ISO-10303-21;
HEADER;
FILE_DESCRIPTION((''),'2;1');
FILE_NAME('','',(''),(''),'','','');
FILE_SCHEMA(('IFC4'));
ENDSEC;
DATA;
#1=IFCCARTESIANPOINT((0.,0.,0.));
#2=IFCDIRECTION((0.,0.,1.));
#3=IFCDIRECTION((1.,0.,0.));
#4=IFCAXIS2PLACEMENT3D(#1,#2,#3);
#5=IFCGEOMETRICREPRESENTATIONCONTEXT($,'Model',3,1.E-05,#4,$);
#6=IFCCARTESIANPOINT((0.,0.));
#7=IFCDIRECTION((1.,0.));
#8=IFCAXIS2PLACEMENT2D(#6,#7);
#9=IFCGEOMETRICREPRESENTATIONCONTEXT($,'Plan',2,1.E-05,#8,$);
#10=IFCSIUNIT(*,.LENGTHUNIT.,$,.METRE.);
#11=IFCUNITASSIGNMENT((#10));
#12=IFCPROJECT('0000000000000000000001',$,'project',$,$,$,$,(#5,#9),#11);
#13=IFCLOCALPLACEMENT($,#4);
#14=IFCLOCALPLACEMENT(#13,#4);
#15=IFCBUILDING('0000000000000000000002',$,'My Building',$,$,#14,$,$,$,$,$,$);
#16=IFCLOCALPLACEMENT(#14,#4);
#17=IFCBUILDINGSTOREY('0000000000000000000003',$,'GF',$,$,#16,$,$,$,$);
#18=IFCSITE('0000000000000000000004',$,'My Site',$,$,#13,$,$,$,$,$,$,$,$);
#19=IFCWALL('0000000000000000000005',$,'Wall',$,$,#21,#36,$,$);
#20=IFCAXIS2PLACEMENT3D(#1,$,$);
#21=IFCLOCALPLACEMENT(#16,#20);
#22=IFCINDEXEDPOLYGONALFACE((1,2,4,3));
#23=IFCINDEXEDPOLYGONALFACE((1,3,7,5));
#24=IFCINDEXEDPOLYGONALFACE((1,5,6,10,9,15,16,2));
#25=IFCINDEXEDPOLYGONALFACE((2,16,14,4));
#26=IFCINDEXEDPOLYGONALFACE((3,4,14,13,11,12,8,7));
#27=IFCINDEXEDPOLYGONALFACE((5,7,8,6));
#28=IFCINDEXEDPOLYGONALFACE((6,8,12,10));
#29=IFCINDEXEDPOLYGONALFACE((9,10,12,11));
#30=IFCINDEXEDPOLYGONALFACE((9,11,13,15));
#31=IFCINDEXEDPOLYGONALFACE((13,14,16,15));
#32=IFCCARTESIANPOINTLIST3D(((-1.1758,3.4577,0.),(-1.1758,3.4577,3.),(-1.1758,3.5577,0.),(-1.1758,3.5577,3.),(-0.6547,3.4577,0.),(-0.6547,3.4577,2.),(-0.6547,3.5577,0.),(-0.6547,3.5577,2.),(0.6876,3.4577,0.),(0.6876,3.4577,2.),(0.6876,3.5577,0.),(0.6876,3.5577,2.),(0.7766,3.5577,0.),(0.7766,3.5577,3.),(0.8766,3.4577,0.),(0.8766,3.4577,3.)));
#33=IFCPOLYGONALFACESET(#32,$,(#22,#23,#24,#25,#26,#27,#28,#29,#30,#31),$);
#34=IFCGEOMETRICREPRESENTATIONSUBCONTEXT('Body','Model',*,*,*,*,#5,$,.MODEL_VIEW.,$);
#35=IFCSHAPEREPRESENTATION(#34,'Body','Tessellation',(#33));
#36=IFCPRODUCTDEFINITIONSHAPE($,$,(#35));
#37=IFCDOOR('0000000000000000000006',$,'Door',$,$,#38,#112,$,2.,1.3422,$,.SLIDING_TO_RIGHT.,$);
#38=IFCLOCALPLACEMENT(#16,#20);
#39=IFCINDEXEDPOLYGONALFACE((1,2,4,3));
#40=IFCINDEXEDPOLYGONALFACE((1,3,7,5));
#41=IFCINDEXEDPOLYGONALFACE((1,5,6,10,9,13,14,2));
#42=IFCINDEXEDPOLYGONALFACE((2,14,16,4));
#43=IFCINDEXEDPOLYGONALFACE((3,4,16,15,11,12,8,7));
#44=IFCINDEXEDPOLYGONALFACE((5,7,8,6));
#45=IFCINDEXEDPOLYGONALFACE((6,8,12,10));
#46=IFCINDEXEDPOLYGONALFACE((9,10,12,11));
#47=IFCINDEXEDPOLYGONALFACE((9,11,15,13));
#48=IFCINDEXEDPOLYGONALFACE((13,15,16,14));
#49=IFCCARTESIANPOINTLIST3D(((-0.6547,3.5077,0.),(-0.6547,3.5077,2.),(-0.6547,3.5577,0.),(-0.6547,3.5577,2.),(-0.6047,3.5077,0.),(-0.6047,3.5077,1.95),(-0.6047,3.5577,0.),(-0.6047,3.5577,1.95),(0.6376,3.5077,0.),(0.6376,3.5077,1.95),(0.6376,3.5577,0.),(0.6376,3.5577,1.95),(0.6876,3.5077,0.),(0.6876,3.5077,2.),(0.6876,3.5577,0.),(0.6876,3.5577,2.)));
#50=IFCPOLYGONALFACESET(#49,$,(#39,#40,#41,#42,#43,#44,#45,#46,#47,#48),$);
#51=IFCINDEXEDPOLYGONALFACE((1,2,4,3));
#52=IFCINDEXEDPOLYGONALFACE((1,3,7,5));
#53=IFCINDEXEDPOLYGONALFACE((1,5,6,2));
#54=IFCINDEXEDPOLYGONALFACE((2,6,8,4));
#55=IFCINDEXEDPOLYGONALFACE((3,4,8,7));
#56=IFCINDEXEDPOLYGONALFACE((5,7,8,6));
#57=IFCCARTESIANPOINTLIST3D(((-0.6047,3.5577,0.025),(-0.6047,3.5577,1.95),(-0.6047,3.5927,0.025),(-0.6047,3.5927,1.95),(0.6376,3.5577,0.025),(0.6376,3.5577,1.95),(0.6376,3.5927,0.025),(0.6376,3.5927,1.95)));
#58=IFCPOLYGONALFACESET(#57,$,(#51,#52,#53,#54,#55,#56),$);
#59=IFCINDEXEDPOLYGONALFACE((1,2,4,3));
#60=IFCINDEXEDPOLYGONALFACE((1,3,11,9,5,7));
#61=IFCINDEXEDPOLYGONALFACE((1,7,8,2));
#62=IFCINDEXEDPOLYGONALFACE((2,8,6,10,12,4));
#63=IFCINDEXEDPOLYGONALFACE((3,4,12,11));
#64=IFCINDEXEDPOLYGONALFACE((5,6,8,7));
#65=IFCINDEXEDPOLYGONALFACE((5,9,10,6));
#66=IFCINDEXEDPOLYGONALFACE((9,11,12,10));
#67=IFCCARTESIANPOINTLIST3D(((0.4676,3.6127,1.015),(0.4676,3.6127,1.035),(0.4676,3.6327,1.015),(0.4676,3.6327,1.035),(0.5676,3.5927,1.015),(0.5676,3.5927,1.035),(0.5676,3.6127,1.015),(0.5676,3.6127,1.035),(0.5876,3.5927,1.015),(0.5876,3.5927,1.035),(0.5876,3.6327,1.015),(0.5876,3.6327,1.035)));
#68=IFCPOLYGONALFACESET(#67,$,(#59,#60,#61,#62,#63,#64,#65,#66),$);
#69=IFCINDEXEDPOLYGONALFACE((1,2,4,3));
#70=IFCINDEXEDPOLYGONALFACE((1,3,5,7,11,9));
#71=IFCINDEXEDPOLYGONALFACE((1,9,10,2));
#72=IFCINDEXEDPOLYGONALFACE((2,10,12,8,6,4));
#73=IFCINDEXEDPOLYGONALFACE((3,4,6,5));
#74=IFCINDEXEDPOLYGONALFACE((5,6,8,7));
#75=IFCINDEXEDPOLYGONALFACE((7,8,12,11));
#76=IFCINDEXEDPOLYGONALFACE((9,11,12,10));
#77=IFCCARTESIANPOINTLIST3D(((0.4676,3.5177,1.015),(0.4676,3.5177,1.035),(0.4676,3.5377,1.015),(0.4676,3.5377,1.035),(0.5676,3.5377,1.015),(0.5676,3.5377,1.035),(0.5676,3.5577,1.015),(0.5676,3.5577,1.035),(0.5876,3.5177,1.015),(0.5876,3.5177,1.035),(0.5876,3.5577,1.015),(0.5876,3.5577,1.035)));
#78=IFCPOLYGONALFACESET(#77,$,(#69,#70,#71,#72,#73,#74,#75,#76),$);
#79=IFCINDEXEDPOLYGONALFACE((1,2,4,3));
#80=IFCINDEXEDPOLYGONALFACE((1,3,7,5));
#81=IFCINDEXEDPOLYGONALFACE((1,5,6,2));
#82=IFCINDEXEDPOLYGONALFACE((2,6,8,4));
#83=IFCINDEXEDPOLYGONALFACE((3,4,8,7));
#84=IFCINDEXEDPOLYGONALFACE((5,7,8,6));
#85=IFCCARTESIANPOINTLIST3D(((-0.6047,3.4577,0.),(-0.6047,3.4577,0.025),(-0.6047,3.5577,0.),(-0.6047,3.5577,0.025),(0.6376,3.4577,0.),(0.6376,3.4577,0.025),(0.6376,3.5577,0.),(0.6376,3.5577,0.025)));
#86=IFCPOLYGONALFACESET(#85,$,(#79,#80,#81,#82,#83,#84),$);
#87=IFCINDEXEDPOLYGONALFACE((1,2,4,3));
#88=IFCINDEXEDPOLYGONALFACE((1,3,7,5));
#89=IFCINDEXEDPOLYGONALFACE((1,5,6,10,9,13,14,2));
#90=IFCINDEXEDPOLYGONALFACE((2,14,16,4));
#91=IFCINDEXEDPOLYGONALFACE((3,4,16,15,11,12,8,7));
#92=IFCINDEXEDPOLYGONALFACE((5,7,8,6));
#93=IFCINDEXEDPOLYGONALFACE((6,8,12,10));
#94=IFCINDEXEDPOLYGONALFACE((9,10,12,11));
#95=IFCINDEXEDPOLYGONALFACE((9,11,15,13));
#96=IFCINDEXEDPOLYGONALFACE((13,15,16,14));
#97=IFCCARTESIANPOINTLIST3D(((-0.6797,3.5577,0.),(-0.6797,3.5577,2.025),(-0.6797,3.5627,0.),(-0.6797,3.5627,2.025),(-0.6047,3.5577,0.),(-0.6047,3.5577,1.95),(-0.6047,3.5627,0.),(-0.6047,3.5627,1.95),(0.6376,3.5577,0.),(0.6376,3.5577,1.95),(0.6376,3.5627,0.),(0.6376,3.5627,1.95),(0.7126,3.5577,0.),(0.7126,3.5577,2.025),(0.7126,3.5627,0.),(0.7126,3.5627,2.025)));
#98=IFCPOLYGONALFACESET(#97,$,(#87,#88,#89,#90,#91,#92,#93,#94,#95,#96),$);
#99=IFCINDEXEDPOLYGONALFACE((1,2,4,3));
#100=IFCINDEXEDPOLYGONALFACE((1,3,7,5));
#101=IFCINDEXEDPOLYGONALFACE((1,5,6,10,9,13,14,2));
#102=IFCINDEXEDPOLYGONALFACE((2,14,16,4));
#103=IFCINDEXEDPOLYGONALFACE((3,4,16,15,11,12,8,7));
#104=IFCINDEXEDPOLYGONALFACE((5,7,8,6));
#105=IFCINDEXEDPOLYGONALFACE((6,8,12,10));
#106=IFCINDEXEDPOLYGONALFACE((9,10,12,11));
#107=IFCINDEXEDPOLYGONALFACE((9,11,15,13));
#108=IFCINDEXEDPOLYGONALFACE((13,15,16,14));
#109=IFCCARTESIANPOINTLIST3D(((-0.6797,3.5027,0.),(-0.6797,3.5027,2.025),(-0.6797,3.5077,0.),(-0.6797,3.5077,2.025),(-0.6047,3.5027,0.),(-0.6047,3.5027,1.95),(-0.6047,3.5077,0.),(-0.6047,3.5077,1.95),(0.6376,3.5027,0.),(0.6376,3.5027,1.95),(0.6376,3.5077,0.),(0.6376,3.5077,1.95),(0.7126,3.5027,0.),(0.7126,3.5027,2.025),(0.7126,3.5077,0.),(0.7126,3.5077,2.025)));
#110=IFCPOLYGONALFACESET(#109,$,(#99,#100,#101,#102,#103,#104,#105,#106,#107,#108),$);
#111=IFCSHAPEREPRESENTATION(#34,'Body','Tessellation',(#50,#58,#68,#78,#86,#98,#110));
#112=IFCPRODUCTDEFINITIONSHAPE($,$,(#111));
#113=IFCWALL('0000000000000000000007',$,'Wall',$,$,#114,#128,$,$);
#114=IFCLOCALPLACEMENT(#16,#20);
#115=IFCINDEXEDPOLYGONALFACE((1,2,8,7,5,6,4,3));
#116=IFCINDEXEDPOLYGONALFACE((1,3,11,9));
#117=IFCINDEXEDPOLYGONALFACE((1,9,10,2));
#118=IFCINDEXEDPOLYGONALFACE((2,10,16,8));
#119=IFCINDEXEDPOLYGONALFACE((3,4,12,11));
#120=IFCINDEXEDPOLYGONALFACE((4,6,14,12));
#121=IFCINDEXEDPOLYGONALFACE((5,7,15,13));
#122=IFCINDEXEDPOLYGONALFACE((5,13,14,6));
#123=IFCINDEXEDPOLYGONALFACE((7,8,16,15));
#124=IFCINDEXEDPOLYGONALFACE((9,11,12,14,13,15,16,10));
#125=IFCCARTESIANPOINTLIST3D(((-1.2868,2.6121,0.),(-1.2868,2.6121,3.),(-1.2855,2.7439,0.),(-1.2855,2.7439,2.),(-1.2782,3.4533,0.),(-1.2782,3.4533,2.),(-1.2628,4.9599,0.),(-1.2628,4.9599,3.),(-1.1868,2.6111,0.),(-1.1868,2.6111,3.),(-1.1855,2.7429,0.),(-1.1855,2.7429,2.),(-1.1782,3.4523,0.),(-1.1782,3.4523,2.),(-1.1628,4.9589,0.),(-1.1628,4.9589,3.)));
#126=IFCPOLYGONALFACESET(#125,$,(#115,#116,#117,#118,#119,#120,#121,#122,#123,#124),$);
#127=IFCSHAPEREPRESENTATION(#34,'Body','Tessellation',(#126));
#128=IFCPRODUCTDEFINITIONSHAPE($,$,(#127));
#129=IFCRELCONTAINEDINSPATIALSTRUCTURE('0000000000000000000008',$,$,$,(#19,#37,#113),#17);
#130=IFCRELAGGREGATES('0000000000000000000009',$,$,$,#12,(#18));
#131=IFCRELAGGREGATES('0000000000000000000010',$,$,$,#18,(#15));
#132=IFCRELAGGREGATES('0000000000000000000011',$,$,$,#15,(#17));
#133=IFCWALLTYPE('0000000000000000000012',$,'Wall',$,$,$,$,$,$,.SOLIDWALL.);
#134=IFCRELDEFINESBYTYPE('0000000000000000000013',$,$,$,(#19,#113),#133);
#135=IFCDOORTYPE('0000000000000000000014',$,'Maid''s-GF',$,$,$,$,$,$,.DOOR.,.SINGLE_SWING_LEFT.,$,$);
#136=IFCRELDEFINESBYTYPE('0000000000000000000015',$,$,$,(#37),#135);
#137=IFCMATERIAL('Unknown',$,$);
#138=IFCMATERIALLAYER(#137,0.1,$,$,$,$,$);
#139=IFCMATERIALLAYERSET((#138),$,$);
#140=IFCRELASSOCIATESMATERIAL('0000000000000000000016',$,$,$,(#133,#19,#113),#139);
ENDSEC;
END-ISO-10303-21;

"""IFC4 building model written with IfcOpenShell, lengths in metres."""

from ifc_helpers import new_model, entity, si_unit, frame, origin_with_axes, origin_2d_with_axis, place, context, subcontext, project, spatial, line, indexed_curve, outline, extrude, shape, source, transform, mapped, material, layer, layer_set, layer_usage, type_object, type_shapes, element, fill, save


model = new_model("IFC4")

# Units and contexts
model_context = context("Model", 3, precision=1e-05, world=origin_with_axes())
plan_context = context("Plan", 2, precision=1e-05, world=origin_2d_with_axis())
body_context_1 = subcontext(model_context, "Body", "Model", "MODEL_VIEW")
body_context_2 = subcontext(plan_context, "Body", "Plan", "PLAN_VIEW")
ifc_project = project(units=[si_unit("LENGTHUNIT", "METRE")], contexts=[model_context, plan_context])

# Site, building, storey
site_placement = place(None, origin_with_axes())
site = spatial("IfcSite", under=ifc_project, at=site_placement, Name="My Site")
building_placement = place(site_placement, origin_with_axes())
building = spatial("IfcBuilding", under=site, at=building_placement, Name="My Building")
storey_placement = place(building_placement, origin_with_axes())
storey = spatial("IfcBuildingStorey", under=building, at=storey_placement, Name="GF")

# Shared definitions
ifc_material = material(Name="Unknown")
ifc_layer = layer(ifc_material, 0.1)
ifc_layer_set = layer_set([ifc_layer])
wall_type = type_object("IfcWallType", Name="Wall", PredefinedType="SOLIDWALL", material=ifc_layer_set)

# Shared definitions
shared_shape_1 = source(origin_with_axes(), body_context_1, "Body", "SweptSolid", [
    extrude(outline(indexed_curve([(0.0, 0.0), (0.7094, 0.0), (0.7094, 2.0), (0.0, 2.0)], segments=[line(1, 2, 3, 4, 1)])), frame((0.0, -0.6, 0.0), z_axis=(0.0, -1.0, 0.0), x_axis=(1.0, 0.0, 0.0)), (0.0, 0.0, -1.0), 1.2),
])

# Wall, opening, door
ifc_layer_usage_1 = layer_usage(ifc_layer_set, "AXIS2", "POSITIVE", 0.0)
wall_1_placement = place(storey_placement, frame((0.7766, 3.5577, 0.0), z_axis=(0.0, 0.0, 1.0), x_axis=(-1.0, 0.0, 0.0)))
wall_1 = element("IfcWall", 1, at=wall_1_placement, inside=storey, type_object=wall_type, material=ifc_layer_usage_1, Name="Wall", context=body_context_1, shape_type="SweptSolid", body=[
    extrude(outline(indexed_curve([(0.0, 0.0), (-0.1, 0.1), (1.9525, 0.1), (1.9525, 0.0)], segments=[line(1, 2, 3, 4, 1)])), origin_with_axes(), (0.0, 0.0, 1.0), 3.0),
])
shared_shape_2 = source(origin_with_axes(), body_context_1, "Body", "SweptSolid", [
    extrude(outline(indexed_curve([(0.0, 0.0), (1.3422, 0.0), (1.3422, 2.0), (0.0, 2.0)], segments=[line(1, 2, 3, 4, 1)])), frame((0.0, -0.6, 0.0), z_axis=(0.0, -1.0, 0.0), x_axis=(1.0, 0.0, 0.0)), (0.0, 0.0, -1.0), 1.2),
])
opening_1_placement = place(wall_1_placement, frame((0.089, 0.0, 0.0), z_axis=(0.0, 0.0, 1.0), x_axis=(1.0, -0.000001, 0.0)))
opening_1 = element("IfcOpeningElement", 2, at=opening_1_placement, cuts=wall_1, PredefinedType="OPENING", context=body_context_1, shape_type="MappedRepresentation", body=[
    mapped(shared_shape_2, transform((0.0, 0.0, 0.0), x_axis=(1.0, 0.0, 0.0), y_axis=(0.0, 1.0, 0.0), z_axis=(0.0, 0.0, 1.0), scale=1.0)),
])
door_type_1 = type_object("IfcDoorType", Name="Maid's-GF", OperationType="SINGLE_SWING_LEFT", PredefinedType="DOOR")
shared_shape_3 = source(origin_with_axes(), body_context_1, "Body", "SweptSolid", [
    extrude(outline(indexed_curve([(0.0, 0.0), (0.0, 2.0), (1.3422, 2.0), (1.3422, 0.0), (1.2922, 0.0), (1.2922, 1.95), (0.05, 1.95), (0.05, 0.0)], segments=[line(1, 2, 3, 4, 5, 6, 7, 8, 1)])), frame((0.0, 0.0, 0.0), z_axis=(0.0, -1.0, 0.0), x_axis=(1.0, 0.0, 0.0)), (0.0, 0.0, -1.0), 0.05),
    extrude(outline(indexed_curve([(0.0, 0.0), (1.2422, 0.0), (1.2422, 0.035), (0.0, 0.035)], segments=[line(1, 2, 3, 4, 1)])), frame((0.05, -0.035, 0.025), z_axis=(0.0, 0.0, 1.0), x_axis=(1.0, 0.0, 0.0)), (0.0, 0.0, 1.0), 1.925),
    extrude(outline(indexed_curve([(0.0, 0.0), (0.0, -0.04), (0.12, -0.04), (0.12, -0.02), (0.02, -0.02), (0.02, 0.0)], segments=[line(1, 2, 3, 4, 5, 6, 1)])), frame((0.1, -0.035, 1.015), z_axis=(0.0, 0.0, 1.0), x_axis=(1.0, 0.0, 0.0)), (0.0, 0.0, 1.0), 0.02),
    extrude(outline(indexed_curve([(0.0, 0.0), (0.0, 0.04), (0.12, 0.04), (0.12, 0.02), (0.02, 0.02), (0.02, 0.0)], segments=[line(1, 2, 3, 4, 5, 6, 1)])), frame((0.1, 0.0, 1.015), z_axis=(0.0, 0.0, 1.0), x_axis=(1.0, 0.0, 0.0)), (0.0, 0.0, 1.0), 0.02),
    extrude(outline(indexed_curve([(0.0, 0.0), (1.2422, 0.0), (1.2422, 0.1), (0.0, 0.1)], segments=[line(1, 2, 3, 4, 1)])), frame((0.05, 0.0, 0.0), z_axis=(0.0, 0.0, 1.0), x_axis=(1.0, 0.0, 0.0)), (0.0, 0.0, 1.0), 0.025),
    extrude(outline(indexed_curve([(0.0, 0.0), (0.0, 2.025), (1.3922, 2.025), (1.3922, 0.0), (1.3172, 0.0), (1.3172, 1.95), (0.075, 1.95), (0.075, 0.0)], segments=[line(1, 2, 3, 4, 5, 6, 7, 8, 1)])), frame((-0.025, -0.005, 0.0), z_axis=(0.0, -1.0, 0.0), x_axis=(1.0, 0.0, 0.0)), (0.0, 0.0, -1.0), 0.005),
    extrude(outline(indexed_curve([(0.0, 0.0), (0.0, 2.025), (1.3922, 2.025), (1.3922, 0.0), (1.3172, 0.0), (1.3172, 1.95), (0.075, 1.95), (0.075, 0.0)], segments=[line(1, 2, 3, 4, 5, 6, 7, 8, 1)])), frame((-0.025, 0.05, 0.0), z_axis=(0.0, -1.0, 0.0), x_axis=(1.0, 0.0, 0.0)), (0.0, 0.0, -1.0), 0.005),
])
shared_shape_4 = source(origin_with_axes(), body_context_2, "Body", "Curve2D", [
    entity("IfcIndexedPolyCurve", entity("IfcCartesianPointList2D", [[0.0, 0.0], [0.05, 0.0], [0.05, 0.05], [0.0, 0.05]]), [entity("IfcLineIndex", [1, 2, 3, 4, 1])]),
    entity("IfcIndexedPolyCurve", entity("IfcCartesianPointList2D", [[1.3422, 0.0], [1.2922, 0.0], [1.2922, 0.05], [1.3422, 0.05]]), [entity("IfcLineIndex", [1, 2, 3, 4, 1])]),
    entity("IfcIndexedPolyCurve", entity("IfcCartesianPointList2D", [[1.9134, -0.035], [0.6711, -0.035], [0.6711, 0.0], [1.9134, 0.0]]), [entity("IfcLineIndex", [1, 2, 3, 4, 1])]),
])
type_shapes(door_type_1, [shared_shape_3, shared_shape_4])
door_1_placement = place(opening_1_placement, frame((0.0, 0.0, 0.0), z_axis=(0.0, 0.0, 1.0), x_axis=(1.0, 0.0, 0.0)))
door_1 = element("IfcDoor", 3, at=door_1_placement, inside=storey, type_object=door_type_1, Name="Door", OperationType="SLIDING_TO_RIGHT", OverallHeight=2.0, OverallWidth=1.3422, shapes=[
    shape(body_context_1, "Body", "MappedRepresentation", [mapped(shared_shape_3, transform((0.0, 0.0, 0.0), x_axis=(1.0, 0.0, 0.0), y_axis=(0.0, 1.0, 0.0), z_axis=(0.0, 0.0, 1.0), scale=1.0))]),
    shape(body_context_2, "Body", "MappedRepresentation", [mapped(shared_shape_4, transform((0.0, 0.0, 0.0), x_axis=(1.0, 0.0, 0.0), y_axis=(0.0, 1.0, 0.0), z_axis=(0.0, 0.0, 1.0), scale=1.0))]),
])
fill(opening_1, door_1)

# Wall, opening
ifc_layer_usage_2 = layer_usage(ifc_layer_set, "AXIS2", "POSITIVE", 0.0)
wall_2_placement = place(storey_placement, frame((-1.2628, 4.9599, 0.0), z_axis=(0.0, 0.0, 1.0), x_axis=(-0.01024, -0.999948, 0.0)))
wall_2 = element("IfcWall", 4, at=wall_2_placement, inside=storey, type_object=wall_type, material=ifc_layer_usage_2, Name="Wall", context=body_context_1, shape_type="SweptSolid", body=[
    extrude(outline(indexed_curve([(0.0, 0.0), (0.0, 0.1), (2.3479, 0.1), (2.3479, 0.0)], segments=[line(1, 2, 3, 4, 1)])), origin_with_axes(), (0.0, 0.0, 1.0), 3.0),
])
opening_2_placement = place(wall_2_placement, frame((2.2161, 0.1, 0.0), z_axis=(0.0, 0.0, 1.0), x_axis=(-1.0, 0.0, 0.0)))
element("IfcOpeningElement", 5, at=opening_2_placement, cuts=wall_2, PredefinedType="OPENING", context=body_context_1, shape_type="MappedRepresentation", body=[
    mapped(shared_shape_1, transform((0.0, 0.0, 0.0), x_axis=(1.0, 0.0, 0.0), y_axis=(0.0, 1.0, 0.0), z_axis=(0.0, 0.0, 1.0), scale=1.0)),
])

save(model, "model.ifc")
